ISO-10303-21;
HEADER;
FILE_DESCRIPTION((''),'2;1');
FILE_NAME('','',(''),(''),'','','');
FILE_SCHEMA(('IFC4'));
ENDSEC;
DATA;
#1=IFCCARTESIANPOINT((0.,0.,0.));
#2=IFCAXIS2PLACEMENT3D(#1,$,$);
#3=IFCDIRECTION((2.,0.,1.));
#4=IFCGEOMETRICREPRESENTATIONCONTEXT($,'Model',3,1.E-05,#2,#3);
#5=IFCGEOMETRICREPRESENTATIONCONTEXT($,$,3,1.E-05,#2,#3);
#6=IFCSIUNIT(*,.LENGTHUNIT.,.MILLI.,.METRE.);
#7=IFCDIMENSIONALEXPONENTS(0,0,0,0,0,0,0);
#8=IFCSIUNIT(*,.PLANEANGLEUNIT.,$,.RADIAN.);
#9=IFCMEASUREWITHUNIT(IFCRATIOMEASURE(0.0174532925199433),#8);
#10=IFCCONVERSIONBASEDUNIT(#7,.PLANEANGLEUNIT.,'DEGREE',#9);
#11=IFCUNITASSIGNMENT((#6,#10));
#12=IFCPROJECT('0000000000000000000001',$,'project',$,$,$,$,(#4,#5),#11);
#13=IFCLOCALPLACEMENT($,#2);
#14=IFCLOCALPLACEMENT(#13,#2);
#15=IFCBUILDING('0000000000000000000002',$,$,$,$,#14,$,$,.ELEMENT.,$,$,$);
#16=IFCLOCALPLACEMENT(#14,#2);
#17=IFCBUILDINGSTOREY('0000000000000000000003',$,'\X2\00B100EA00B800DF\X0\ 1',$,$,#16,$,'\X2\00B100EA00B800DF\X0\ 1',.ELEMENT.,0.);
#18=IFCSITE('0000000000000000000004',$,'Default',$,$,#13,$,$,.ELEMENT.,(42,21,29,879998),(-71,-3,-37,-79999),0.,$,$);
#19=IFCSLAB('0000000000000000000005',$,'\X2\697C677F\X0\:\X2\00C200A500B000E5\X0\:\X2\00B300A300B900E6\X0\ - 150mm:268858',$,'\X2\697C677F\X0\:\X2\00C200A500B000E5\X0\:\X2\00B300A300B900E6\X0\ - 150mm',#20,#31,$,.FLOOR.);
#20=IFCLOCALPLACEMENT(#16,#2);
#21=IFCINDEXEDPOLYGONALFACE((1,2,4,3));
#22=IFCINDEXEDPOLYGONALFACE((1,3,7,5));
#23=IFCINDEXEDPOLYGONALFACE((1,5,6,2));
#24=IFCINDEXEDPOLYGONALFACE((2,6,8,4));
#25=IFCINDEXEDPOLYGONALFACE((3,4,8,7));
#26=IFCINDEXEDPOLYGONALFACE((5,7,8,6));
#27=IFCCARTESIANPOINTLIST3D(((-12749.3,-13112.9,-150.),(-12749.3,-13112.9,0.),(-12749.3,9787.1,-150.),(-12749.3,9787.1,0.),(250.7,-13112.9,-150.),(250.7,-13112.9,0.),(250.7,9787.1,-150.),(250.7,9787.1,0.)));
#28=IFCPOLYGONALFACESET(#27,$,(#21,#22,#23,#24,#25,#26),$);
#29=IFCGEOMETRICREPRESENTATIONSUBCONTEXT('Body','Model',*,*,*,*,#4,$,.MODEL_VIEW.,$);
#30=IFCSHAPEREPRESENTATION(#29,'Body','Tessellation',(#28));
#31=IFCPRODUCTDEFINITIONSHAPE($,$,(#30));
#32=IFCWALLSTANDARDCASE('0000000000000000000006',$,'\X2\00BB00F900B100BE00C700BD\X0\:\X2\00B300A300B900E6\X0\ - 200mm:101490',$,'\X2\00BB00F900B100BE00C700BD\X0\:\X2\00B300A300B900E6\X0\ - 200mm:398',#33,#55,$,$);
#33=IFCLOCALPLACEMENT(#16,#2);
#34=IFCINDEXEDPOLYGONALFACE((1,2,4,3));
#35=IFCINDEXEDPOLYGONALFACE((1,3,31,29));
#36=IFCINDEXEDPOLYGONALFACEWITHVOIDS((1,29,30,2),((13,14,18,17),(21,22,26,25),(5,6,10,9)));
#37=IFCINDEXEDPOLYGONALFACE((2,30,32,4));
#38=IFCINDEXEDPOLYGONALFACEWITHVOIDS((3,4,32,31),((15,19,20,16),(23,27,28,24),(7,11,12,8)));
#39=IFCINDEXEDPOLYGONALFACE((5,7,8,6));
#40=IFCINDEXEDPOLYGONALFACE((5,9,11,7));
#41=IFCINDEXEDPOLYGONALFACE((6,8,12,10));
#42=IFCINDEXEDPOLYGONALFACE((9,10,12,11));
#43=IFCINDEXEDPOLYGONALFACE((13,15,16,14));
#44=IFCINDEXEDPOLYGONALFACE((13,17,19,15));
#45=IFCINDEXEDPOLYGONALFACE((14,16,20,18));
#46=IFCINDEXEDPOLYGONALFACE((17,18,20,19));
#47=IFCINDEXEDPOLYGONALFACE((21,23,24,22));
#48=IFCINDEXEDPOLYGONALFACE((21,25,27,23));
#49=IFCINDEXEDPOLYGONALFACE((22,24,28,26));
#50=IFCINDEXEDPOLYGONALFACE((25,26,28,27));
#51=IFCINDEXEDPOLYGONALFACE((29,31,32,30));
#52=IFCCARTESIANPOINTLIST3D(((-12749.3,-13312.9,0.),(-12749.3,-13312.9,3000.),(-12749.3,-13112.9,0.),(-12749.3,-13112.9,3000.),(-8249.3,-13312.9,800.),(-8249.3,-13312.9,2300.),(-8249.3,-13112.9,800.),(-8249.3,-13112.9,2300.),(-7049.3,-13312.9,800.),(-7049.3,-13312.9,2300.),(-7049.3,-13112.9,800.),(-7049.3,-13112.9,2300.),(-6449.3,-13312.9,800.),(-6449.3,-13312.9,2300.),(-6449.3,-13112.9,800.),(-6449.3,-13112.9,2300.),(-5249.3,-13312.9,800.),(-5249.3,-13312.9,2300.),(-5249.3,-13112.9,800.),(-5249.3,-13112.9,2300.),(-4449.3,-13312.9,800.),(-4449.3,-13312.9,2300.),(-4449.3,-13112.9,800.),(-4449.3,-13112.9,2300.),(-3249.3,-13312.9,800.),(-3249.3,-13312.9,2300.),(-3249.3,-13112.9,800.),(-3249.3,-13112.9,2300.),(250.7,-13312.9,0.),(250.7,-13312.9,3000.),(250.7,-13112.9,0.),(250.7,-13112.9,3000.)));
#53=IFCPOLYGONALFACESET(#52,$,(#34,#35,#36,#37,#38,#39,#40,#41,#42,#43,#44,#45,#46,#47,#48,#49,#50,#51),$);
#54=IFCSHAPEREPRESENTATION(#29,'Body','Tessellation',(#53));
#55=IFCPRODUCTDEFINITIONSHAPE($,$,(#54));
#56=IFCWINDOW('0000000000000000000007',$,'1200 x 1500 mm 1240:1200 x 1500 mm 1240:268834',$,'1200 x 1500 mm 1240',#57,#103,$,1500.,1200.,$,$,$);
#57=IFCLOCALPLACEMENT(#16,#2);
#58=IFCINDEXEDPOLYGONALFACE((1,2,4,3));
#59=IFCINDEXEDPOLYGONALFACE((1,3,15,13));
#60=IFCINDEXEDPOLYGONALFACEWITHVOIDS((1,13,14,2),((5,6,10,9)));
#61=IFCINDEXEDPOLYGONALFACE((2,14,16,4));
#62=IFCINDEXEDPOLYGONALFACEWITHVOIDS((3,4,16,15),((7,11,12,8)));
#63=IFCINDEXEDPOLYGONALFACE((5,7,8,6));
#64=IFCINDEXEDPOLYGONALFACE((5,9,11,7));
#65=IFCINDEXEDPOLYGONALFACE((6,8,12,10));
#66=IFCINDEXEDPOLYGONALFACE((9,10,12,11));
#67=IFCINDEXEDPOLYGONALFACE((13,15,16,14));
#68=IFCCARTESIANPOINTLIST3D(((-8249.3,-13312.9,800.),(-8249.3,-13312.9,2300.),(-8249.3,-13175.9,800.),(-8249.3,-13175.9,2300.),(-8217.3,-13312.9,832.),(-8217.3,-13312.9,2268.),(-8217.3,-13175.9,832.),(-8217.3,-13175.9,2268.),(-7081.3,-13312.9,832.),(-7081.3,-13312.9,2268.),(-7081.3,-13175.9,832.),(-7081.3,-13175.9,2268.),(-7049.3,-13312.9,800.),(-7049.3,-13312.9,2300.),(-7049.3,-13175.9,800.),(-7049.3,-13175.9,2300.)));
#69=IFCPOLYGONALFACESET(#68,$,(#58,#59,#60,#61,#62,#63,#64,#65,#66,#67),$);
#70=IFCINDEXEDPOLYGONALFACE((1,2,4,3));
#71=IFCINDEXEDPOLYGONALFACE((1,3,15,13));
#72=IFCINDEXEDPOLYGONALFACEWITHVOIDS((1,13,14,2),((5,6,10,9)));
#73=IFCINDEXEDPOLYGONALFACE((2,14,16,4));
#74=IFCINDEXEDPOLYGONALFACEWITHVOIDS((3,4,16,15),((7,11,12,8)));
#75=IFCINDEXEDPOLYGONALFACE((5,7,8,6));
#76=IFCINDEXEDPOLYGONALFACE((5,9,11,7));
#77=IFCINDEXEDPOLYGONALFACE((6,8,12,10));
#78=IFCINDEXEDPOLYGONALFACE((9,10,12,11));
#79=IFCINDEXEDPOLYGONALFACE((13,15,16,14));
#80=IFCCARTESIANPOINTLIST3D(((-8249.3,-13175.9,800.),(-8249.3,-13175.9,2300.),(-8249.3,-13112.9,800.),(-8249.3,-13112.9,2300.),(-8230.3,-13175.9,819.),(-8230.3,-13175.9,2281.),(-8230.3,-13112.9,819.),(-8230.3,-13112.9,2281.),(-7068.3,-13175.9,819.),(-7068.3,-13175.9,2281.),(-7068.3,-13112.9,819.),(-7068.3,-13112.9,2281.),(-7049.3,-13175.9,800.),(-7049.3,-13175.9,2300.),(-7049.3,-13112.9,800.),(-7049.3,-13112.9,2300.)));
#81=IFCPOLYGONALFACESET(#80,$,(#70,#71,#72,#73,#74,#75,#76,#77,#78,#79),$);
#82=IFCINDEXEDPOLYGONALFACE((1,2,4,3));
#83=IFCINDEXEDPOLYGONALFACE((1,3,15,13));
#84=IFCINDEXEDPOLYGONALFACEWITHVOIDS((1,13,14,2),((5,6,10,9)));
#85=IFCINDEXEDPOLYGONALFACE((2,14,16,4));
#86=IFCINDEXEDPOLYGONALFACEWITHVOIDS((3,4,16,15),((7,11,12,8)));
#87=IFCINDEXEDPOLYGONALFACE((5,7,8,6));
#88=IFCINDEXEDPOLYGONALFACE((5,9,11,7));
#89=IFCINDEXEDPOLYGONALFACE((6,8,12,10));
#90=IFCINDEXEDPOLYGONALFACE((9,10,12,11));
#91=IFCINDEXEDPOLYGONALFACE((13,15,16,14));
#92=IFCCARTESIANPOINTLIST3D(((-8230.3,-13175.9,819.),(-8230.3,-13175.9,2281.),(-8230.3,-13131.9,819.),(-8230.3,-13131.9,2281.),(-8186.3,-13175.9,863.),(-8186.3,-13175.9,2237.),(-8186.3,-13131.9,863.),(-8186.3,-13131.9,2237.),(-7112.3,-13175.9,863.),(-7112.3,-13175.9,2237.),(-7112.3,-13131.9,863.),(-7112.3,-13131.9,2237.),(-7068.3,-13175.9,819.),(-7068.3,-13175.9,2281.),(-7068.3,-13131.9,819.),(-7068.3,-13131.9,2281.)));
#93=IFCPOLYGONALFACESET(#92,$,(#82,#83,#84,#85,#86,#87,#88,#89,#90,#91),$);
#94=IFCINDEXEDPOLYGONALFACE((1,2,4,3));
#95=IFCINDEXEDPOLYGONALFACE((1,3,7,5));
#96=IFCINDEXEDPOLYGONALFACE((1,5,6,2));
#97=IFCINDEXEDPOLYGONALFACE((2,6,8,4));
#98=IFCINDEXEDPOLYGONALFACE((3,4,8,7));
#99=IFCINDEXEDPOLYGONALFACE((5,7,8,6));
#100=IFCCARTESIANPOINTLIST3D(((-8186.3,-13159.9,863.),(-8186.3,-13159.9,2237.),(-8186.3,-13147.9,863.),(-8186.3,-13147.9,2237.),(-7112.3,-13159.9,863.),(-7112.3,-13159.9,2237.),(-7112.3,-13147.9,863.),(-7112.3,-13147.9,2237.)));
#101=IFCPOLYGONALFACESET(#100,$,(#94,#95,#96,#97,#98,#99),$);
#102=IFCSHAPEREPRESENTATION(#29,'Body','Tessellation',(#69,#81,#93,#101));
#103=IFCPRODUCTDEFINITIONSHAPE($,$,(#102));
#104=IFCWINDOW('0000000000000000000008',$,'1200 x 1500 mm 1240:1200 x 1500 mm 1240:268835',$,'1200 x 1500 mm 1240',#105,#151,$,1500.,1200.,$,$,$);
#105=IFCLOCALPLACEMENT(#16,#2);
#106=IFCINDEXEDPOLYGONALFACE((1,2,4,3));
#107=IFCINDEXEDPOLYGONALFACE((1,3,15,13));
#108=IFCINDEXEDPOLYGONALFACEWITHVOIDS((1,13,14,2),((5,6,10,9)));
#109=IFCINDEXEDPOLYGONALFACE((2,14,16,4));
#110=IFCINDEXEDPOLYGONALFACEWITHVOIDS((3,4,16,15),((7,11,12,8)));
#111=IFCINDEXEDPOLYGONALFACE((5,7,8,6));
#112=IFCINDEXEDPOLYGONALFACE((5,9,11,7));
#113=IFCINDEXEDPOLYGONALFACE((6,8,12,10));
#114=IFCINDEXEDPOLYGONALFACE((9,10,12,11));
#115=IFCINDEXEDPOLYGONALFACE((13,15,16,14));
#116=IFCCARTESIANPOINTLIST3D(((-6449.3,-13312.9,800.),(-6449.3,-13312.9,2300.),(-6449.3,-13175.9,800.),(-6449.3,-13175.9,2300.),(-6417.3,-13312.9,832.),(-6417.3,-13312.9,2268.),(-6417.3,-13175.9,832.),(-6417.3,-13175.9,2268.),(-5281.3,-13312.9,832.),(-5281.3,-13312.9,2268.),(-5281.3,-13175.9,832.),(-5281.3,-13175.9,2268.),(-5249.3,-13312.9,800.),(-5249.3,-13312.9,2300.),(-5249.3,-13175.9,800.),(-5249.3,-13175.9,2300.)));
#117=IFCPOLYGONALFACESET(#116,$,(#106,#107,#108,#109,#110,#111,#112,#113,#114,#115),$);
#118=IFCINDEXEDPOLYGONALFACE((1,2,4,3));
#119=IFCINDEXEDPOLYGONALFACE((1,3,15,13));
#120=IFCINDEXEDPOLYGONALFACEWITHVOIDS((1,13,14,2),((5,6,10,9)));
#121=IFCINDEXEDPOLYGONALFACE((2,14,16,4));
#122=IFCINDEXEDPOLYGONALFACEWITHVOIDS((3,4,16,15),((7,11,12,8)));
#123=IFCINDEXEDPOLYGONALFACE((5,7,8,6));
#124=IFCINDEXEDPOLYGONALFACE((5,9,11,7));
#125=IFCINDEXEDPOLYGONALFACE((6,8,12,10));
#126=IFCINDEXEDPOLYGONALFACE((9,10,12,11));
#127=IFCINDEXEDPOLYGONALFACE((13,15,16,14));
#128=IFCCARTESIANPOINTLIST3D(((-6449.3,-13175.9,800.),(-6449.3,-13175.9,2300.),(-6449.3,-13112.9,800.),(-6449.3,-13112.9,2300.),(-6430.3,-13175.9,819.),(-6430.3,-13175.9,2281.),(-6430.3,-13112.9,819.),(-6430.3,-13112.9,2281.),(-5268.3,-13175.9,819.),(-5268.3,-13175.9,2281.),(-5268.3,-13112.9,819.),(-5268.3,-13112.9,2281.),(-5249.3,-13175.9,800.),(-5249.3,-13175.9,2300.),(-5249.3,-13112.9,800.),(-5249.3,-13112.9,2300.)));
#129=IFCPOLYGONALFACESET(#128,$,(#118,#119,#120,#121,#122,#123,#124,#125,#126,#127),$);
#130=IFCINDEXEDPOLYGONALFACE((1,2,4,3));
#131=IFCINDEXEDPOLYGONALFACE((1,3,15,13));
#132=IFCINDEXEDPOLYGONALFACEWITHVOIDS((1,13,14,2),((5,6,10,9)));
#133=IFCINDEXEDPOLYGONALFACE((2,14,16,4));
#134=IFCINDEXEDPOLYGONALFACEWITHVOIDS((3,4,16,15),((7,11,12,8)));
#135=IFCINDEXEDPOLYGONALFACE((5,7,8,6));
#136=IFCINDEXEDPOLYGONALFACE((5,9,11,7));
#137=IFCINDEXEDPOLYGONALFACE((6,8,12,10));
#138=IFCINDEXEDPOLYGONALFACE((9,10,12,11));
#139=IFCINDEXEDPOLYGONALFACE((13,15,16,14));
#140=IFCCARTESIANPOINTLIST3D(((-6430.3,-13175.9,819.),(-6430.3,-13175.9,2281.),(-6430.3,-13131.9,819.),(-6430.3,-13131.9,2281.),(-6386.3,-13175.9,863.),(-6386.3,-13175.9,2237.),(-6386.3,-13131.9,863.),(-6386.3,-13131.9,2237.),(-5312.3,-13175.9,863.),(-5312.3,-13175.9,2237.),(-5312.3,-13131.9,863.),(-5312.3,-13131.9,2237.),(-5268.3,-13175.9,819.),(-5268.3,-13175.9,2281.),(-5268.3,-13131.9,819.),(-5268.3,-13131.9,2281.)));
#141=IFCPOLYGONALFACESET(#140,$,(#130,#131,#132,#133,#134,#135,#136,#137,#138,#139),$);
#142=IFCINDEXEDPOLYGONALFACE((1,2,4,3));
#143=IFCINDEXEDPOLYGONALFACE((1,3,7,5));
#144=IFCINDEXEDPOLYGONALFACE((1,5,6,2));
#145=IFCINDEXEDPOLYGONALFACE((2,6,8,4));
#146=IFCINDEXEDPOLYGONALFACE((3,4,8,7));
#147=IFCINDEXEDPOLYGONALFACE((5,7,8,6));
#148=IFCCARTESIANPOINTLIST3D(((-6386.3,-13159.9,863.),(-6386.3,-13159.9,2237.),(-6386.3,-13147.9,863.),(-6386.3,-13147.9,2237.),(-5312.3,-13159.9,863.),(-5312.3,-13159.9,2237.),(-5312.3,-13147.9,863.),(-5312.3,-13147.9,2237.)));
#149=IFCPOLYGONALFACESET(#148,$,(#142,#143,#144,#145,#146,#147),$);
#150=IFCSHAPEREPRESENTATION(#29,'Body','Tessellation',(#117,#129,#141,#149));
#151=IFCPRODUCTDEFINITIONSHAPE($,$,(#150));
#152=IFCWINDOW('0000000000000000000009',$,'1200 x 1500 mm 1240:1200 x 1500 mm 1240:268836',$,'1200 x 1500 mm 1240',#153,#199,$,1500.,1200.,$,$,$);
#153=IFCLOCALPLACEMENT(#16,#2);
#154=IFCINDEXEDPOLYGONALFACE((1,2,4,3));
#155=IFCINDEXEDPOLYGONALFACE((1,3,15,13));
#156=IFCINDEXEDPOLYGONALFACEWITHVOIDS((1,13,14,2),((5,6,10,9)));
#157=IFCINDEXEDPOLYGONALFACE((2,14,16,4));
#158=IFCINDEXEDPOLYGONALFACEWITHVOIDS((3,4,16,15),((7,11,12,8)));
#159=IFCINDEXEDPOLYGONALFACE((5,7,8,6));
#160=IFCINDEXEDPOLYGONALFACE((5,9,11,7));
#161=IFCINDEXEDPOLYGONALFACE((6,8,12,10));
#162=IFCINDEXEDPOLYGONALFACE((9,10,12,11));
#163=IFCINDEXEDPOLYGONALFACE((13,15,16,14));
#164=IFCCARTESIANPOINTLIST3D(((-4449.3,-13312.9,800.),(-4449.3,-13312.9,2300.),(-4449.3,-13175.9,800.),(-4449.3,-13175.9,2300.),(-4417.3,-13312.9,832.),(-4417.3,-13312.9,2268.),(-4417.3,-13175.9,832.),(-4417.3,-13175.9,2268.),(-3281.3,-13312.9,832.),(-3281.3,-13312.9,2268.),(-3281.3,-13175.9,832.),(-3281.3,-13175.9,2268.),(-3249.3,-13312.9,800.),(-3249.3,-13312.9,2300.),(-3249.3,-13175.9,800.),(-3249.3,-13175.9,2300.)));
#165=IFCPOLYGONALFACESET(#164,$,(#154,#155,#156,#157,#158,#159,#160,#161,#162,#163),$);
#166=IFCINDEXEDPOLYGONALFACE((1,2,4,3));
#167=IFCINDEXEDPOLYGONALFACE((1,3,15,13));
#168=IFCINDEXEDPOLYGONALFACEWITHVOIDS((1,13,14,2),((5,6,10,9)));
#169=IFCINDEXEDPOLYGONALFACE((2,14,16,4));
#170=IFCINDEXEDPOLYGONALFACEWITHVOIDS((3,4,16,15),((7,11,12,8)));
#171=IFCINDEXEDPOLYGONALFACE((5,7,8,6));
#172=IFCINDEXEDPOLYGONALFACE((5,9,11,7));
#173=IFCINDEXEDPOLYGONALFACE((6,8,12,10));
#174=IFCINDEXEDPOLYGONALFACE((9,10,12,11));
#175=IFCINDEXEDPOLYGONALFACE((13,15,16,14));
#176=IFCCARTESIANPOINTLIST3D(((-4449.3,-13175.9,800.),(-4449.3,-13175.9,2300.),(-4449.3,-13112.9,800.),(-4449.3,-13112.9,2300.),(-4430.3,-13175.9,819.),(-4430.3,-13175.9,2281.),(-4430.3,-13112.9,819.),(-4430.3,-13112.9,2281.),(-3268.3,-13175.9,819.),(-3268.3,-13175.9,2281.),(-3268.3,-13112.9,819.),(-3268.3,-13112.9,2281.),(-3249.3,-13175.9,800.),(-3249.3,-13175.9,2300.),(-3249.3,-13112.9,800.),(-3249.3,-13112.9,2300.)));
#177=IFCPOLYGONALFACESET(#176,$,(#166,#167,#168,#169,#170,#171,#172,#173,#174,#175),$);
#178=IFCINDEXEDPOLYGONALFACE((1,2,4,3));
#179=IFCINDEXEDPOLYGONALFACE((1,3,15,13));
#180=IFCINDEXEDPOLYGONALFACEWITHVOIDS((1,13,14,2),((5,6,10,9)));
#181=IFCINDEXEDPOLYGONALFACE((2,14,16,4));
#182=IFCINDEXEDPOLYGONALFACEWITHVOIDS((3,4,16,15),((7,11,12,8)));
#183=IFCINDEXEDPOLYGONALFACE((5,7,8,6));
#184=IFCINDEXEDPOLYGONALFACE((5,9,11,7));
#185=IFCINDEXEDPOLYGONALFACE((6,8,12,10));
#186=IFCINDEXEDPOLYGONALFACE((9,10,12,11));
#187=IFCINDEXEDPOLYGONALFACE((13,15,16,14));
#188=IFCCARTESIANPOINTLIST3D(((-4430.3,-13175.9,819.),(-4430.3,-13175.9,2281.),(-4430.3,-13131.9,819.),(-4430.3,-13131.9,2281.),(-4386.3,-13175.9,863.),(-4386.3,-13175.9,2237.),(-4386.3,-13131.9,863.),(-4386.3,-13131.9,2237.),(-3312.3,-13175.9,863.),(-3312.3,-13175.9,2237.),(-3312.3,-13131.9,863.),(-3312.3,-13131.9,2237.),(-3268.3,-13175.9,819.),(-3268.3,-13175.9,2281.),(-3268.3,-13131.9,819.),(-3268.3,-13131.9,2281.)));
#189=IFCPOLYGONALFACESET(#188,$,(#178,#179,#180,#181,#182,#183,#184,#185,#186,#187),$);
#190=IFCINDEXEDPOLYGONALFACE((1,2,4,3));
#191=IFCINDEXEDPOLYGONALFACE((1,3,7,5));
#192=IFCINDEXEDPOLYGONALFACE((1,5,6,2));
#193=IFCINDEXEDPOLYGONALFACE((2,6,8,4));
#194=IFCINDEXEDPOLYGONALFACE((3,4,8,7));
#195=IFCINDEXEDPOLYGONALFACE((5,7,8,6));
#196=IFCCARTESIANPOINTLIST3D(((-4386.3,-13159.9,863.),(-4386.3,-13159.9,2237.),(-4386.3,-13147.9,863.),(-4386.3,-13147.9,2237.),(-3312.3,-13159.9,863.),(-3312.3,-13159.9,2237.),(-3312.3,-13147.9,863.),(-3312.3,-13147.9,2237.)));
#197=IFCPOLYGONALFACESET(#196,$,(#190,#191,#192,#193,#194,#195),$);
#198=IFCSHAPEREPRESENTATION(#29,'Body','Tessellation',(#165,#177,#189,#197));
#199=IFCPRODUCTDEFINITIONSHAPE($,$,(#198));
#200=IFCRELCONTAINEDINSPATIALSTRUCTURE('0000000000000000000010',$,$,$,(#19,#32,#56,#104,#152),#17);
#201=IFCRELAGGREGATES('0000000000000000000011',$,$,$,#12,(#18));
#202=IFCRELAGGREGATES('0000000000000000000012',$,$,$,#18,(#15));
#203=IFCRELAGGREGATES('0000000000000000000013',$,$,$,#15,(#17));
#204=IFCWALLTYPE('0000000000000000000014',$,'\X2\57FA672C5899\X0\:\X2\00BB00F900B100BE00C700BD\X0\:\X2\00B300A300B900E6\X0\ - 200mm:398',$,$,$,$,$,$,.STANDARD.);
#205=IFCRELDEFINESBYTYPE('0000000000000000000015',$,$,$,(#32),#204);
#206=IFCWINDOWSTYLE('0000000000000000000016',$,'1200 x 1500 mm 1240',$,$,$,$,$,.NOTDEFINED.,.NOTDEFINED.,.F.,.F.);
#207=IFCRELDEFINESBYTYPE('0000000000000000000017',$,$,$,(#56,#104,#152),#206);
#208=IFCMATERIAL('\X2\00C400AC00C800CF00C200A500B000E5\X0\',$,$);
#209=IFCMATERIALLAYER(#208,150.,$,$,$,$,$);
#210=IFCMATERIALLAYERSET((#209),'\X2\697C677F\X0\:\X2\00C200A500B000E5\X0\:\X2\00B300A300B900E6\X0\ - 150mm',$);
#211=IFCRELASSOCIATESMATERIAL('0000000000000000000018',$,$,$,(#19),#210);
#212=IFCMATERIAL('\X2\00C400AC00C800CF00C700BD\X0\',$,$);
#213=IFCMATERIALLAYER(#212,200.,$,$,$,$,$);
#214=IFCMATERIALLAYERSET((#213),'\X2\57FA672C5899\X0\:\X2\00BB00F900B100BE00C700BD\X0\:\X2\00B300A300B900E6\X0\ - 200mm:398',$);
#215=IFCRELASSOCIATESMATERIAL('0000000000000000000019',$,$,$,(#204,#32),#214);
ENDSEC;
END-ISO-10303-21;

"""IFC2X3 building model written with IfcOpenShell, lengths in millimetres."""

from ifc_helpers import new_model, entity, si_unit, converted_unit, direction, frame, frame_2d, origin, origin_2d_with_axis, place, context, subcontext, project, spatial, polyline, rectangle, outline, extrude, source, transform, mapped, material, layer, layer_set, layer_usage, type_object, type_shapes, element, fill, save


model = new_model("IFC2X3")

# Units and contexts
model_context = context("Model", 3, precision=1e-05, world=origin(), true_north=direction((2.0, 0.0, 1.0)))
context_of_model = context(None, 3, precision=1e-05, world=origin(), true_north=direction((2.0, 0.0, 1.0)))
body_context = subcontext(model_context, "Body", "Model", "MODEL_VIEW")
ifc_project = project(units=[si_unit("LENGTHUNIT", "METRE", prefix="MILLI"), converted_unit("PLANEANGLEUNIT", "DEGREE", entity("IfcRatioMeasure", 0.0174532925199433), si_unit("PLANEANGLEUNIT", "RADIAN"), dimensions=[0, 0, 0, 0, 0, 0, 0])], contexts=[model_context, context_of_model])

# Site, building, storey
site_placement = place(None, origin())
site = spatial("IfcSite", under=ifc_project, at=site_placement, Name="Default", CompositionType="ELEMENT", RefLatitude=(42, 21, 29, 879998), RefLongitude=(-71, -3, -37, -79999), RefElevation=0.0)
building_placement = place(site_placement, origin())
building = spatial("IfcBuilding", under=site, at=building_placement, CompositionType="ELEMENT")
storey_placement = place(building_placement, origin())
storey = spatial("IfcBuildingStorey", under=building, at=storey_placement, Name="±ê¸ß 1", LongName="±ê¸ß 1", CompositionType="ELEMENT", Elevation=0.0)

# Slab
ifc_material_1 = material(Name="Ä¬ÈÏÂ¥°å")
ifc_layer_1 = layer(ifc_material_1, 150.0)
ifc_layer_set_1 = layer_set([ifc_layer_1], Name="楼板:Â¥°å:³£¹æ - 150mm")
ifc_layer_usage_1 = layer_usage(ifc_layer_set_1, "AXIS3", "POSITIVE", 0.0)
slab_placement = place(storey_placement, origin())
element("IfcSlab", 1, at=slab_placement, inside=storey, material=ifc_layer_usage_1, Name="楼板:Â¥°å:³£¹æ - 150mm:268858", ObjectType="楼板:Â¥°å:³£¹æ - 150mm", PredefinedType="FLOOR", context=body_context, shape_type="SweptSolid", body=[
    extrude(rectangle(XDim=22900.0, YDim=13000.0, at=origin_2d_with_axis()), frame((-6249.3, -1662.9, 0.0), z_axis=(0.0, 0.0, -1.0), x_axis=(0.0, 1.0, 0.0)), (0.0, 0.0, 1.0), 150.0),
])

# Wall, openings, windows
ifc_material_2 = material(Name="Ä¬ÈÏÇ½")
ifc_layer_2 = layer(ifc_material_2, 200.0)
ifc_layer_set_2 = layer_set([ifc_layer_2], Name="基本墙:»ù±¾Ç½:³£¹æ - 200mm:398")
ifc_layer_usage_2 = layer_usage(ifc_layer_set_2, "AXIS2", "NEGATIVE", 100.0)
wall_type = type_object("IfcWallType", Name="基本墙:»ù±¾Ç½:³£¹æ - 200mm:398", PredefinedType="STANDARD", material=ifc_layer_set_2)
wall_1_placement = place(storey_placement, frame((-12749.3, -13212.9, 0.0)))
wall_1 = element("IfcWallStandardCase", 2, at=wall_1_placement, inside=storey, type_object=wall_type, material=ifc_layer_usage_2, Name="»ù±¾Ç½:³£¹æ - 200mm:101490", ObjectType="»ù±¾Ç½:³£¹æ - 200mm:398", context=body_context, shape_type="SweptSolid", body=[
    extrude(rectangle(XDim=13000.0, YDim=200.0, at=frame_2d((6500.0, 0.0), x_axis=(-1.0, 0.0))), origin(), (0.0, 0.0, 1.0), 3000.0),
])
opening_1_placement = place(wall_1_placement, origin())
opening_1 = element("IfcOpeningElement", 3, at=opening_1_placement, cuts=wall_1, ObjectType="Opening", context=body_context, shape_type="SweptSolid", body=[
    extrude(rectangle(XDim=1500.0, YDim=1200.0, at=frame_2d((0.0, 0.0), x_axis=(0.0, 1.0))), frame((5100.0, -102.0, 1550.0), z_axis=(0.0, 1.0, 0.0), x_axis=(1.0, 0.0, 0.0)), (0.0, 0.0, 1.0), 204.0),
])
opening_2_placement = place(wall_1_placement, origin())
opening_2 = element("IfcOpeningElement", 4, at=opening_2_placement, cuts=wall_1, ObjectType="Opening", context=body_context, shape_type="SweptSolid", body=[
    extrude(rectangle(XDim=1500.0, YDim=1200.0, at=frame_2d((0.0, 0.0), x_axis=(0.0, 1.0))), frame((6900.0, -102.0, 1550.0), z_axis=(0.0, 1.0, 0.0), x_axis=(1.0, 0.0, 0.0)), (0.0, 0.0, 1.0), 204.0),
])
opening_3_placement = place(wall_1_placement, origin())
opening_3 = element("IfcOpeningElement", 5, at=opening_3_placement, cuts=wall_1, ObjectType="Opening", context=body_context, shape_type="SweptSolid", body=[
    extrude(rectangle(XDim=1500.0, YDim=1200.0, at=frame_2d((0.0, 0.0), x_axis=(0.0, 1.0))), frame((8900.0, -102.0, 1550.0), z_axis=(0.0, 1.0, 0.0), x_axis=(1.0, 0.0, 0.0)), (0.0, 0.0, 1.0), 204.0),
])
window_style = type_object("IfcWindowStyle", Name="1200 x 1500 mm 1240", ConstructionType="NOTDEFINED", OperationType="NOTDEFINED", ParameterTakesPrecedence=False, Sizeable=False)
shared_shape = source(origin(), body_context, "Body", "SweptSolid", [
    extrude(outline(polyline([(-750.0, -600.0), (750.0, -600.0), (750.0, 600.0), (-750.0, 600.0), (-750.0, -600.0)]), holes=[polyline([(718.0, 568.0), (718.0, -568.0), (-718.0, -568.0), (-718.0, 568.0), (718.0, 568.0)])]), frame((600.0, -202.0, 750.0), z_axis=(0.0, 1.0, 0.0), x_axis=(0.0, 0.0, -1.0)), (0.0, 0.0, 1.0), 137.0),
    extrude(outline(polyline([(-750.0, -600.0), (750.0, -600.0), (750.0, 600.0), (-750.0, 600.0), (-750.0, -600.0)]), holes=[polyline([(731.0, 581.0), (731.0, -581.0), (-731.0, -581.0), (-731.0, 581.0), (731.0, 581.0)])]), frame((600.0, -65.0, 750.0), z_axis=(0.0, 1.0, 0.0), x_axis=(0.0, 0.0, -1.0)), (0.0, 0.0, 1.0), 63.0),
    extrude(outline(polyline([(-731.0, -581.0), (731.0, -581.0), (731.0, 581.0), (-731.0, 581.0), (-731.0, -581.0)]), holes=[polyline([(687.0, 537.0), (687.0, -537.0), (-687.0, -537.0), (-687.0, 537.0), (687.0, 537.0)])]), frame((600.0, -65.0, 750.0), z_axis=(0.0, 1.0, 0.0), x_axis=(0.0, 0.0, -1.0)), (0.0, 0.0, 1.0), 44.0),
    extrude(rectangle(XDim=1074.0, YDim=12.0, at=origin_2d_with_axis()), frame((600.0, -43.0, 63.0)), (0.0, 0.0, 1.0), 1374.0),
])
type_shapes(window_style, [shared_shape])
window_1_placement = place(opening_1_placement, frame((4500.0, 102.0, 800.0)))
window_1 = element("IfcWindow", 6, at=window_1_placement, inside=storey, type_object=window_style, Name="1200 x 1500 mm 1240:1200 x 1500 mm 1240:268834", ObjectType="1200 x 1500 mm 1240", OverallHeight=1500.0, OverallWidth=1200.0, context=body_context, shape_type="MappedRepresentation", body=[
    mapped(shared_shape, transform((0.0, 0.0, 0.0), scale=1.0)),
])
fill(opening_1, window_1)
window_2_placement = place(opening_2_placement, frame((6300.0, 102.0, 800.0)))
window_2 = element("IfcWindow", 7, at=window_2_placement, inside=storey, type_object=window_style, Name="1200 x 1500 mm 1240:1200 x 1500 mm 1240:268835", ObjectType="1200 x 1500 mm 1240", OverallHeight=1500.0, OverallWidth=1200.0, context=body_context, shape_type="MappedRepresentation", body=[
    mapped(shared_shape, transform((0.0, 0.0, 0.0), scale=1.0)),
])
fill(opening_2, window_2)
window_3_placement = place(opening_3_placement, frame((8300.0, 102.0, 800.0)))
window_3 = element("IfcWindow", 8, at=window_3_placement, inside=storey, type_object=window_style, Name="1200 x 1500 mm 1240:1200 x 1500 mm 1240:268836", ObjectType="1200 x 1500 mm 1240", OverallHeight=1500.0, OverallWidth=1200.0, context=body_context, shape_type="MappedRepresentation", body=[
    mapped(shared_shape, transform((0.0, 0.0, 0.0), scale=1.0)),
])
fill(opening_3, window_3)

save(model, "model.ifc")
